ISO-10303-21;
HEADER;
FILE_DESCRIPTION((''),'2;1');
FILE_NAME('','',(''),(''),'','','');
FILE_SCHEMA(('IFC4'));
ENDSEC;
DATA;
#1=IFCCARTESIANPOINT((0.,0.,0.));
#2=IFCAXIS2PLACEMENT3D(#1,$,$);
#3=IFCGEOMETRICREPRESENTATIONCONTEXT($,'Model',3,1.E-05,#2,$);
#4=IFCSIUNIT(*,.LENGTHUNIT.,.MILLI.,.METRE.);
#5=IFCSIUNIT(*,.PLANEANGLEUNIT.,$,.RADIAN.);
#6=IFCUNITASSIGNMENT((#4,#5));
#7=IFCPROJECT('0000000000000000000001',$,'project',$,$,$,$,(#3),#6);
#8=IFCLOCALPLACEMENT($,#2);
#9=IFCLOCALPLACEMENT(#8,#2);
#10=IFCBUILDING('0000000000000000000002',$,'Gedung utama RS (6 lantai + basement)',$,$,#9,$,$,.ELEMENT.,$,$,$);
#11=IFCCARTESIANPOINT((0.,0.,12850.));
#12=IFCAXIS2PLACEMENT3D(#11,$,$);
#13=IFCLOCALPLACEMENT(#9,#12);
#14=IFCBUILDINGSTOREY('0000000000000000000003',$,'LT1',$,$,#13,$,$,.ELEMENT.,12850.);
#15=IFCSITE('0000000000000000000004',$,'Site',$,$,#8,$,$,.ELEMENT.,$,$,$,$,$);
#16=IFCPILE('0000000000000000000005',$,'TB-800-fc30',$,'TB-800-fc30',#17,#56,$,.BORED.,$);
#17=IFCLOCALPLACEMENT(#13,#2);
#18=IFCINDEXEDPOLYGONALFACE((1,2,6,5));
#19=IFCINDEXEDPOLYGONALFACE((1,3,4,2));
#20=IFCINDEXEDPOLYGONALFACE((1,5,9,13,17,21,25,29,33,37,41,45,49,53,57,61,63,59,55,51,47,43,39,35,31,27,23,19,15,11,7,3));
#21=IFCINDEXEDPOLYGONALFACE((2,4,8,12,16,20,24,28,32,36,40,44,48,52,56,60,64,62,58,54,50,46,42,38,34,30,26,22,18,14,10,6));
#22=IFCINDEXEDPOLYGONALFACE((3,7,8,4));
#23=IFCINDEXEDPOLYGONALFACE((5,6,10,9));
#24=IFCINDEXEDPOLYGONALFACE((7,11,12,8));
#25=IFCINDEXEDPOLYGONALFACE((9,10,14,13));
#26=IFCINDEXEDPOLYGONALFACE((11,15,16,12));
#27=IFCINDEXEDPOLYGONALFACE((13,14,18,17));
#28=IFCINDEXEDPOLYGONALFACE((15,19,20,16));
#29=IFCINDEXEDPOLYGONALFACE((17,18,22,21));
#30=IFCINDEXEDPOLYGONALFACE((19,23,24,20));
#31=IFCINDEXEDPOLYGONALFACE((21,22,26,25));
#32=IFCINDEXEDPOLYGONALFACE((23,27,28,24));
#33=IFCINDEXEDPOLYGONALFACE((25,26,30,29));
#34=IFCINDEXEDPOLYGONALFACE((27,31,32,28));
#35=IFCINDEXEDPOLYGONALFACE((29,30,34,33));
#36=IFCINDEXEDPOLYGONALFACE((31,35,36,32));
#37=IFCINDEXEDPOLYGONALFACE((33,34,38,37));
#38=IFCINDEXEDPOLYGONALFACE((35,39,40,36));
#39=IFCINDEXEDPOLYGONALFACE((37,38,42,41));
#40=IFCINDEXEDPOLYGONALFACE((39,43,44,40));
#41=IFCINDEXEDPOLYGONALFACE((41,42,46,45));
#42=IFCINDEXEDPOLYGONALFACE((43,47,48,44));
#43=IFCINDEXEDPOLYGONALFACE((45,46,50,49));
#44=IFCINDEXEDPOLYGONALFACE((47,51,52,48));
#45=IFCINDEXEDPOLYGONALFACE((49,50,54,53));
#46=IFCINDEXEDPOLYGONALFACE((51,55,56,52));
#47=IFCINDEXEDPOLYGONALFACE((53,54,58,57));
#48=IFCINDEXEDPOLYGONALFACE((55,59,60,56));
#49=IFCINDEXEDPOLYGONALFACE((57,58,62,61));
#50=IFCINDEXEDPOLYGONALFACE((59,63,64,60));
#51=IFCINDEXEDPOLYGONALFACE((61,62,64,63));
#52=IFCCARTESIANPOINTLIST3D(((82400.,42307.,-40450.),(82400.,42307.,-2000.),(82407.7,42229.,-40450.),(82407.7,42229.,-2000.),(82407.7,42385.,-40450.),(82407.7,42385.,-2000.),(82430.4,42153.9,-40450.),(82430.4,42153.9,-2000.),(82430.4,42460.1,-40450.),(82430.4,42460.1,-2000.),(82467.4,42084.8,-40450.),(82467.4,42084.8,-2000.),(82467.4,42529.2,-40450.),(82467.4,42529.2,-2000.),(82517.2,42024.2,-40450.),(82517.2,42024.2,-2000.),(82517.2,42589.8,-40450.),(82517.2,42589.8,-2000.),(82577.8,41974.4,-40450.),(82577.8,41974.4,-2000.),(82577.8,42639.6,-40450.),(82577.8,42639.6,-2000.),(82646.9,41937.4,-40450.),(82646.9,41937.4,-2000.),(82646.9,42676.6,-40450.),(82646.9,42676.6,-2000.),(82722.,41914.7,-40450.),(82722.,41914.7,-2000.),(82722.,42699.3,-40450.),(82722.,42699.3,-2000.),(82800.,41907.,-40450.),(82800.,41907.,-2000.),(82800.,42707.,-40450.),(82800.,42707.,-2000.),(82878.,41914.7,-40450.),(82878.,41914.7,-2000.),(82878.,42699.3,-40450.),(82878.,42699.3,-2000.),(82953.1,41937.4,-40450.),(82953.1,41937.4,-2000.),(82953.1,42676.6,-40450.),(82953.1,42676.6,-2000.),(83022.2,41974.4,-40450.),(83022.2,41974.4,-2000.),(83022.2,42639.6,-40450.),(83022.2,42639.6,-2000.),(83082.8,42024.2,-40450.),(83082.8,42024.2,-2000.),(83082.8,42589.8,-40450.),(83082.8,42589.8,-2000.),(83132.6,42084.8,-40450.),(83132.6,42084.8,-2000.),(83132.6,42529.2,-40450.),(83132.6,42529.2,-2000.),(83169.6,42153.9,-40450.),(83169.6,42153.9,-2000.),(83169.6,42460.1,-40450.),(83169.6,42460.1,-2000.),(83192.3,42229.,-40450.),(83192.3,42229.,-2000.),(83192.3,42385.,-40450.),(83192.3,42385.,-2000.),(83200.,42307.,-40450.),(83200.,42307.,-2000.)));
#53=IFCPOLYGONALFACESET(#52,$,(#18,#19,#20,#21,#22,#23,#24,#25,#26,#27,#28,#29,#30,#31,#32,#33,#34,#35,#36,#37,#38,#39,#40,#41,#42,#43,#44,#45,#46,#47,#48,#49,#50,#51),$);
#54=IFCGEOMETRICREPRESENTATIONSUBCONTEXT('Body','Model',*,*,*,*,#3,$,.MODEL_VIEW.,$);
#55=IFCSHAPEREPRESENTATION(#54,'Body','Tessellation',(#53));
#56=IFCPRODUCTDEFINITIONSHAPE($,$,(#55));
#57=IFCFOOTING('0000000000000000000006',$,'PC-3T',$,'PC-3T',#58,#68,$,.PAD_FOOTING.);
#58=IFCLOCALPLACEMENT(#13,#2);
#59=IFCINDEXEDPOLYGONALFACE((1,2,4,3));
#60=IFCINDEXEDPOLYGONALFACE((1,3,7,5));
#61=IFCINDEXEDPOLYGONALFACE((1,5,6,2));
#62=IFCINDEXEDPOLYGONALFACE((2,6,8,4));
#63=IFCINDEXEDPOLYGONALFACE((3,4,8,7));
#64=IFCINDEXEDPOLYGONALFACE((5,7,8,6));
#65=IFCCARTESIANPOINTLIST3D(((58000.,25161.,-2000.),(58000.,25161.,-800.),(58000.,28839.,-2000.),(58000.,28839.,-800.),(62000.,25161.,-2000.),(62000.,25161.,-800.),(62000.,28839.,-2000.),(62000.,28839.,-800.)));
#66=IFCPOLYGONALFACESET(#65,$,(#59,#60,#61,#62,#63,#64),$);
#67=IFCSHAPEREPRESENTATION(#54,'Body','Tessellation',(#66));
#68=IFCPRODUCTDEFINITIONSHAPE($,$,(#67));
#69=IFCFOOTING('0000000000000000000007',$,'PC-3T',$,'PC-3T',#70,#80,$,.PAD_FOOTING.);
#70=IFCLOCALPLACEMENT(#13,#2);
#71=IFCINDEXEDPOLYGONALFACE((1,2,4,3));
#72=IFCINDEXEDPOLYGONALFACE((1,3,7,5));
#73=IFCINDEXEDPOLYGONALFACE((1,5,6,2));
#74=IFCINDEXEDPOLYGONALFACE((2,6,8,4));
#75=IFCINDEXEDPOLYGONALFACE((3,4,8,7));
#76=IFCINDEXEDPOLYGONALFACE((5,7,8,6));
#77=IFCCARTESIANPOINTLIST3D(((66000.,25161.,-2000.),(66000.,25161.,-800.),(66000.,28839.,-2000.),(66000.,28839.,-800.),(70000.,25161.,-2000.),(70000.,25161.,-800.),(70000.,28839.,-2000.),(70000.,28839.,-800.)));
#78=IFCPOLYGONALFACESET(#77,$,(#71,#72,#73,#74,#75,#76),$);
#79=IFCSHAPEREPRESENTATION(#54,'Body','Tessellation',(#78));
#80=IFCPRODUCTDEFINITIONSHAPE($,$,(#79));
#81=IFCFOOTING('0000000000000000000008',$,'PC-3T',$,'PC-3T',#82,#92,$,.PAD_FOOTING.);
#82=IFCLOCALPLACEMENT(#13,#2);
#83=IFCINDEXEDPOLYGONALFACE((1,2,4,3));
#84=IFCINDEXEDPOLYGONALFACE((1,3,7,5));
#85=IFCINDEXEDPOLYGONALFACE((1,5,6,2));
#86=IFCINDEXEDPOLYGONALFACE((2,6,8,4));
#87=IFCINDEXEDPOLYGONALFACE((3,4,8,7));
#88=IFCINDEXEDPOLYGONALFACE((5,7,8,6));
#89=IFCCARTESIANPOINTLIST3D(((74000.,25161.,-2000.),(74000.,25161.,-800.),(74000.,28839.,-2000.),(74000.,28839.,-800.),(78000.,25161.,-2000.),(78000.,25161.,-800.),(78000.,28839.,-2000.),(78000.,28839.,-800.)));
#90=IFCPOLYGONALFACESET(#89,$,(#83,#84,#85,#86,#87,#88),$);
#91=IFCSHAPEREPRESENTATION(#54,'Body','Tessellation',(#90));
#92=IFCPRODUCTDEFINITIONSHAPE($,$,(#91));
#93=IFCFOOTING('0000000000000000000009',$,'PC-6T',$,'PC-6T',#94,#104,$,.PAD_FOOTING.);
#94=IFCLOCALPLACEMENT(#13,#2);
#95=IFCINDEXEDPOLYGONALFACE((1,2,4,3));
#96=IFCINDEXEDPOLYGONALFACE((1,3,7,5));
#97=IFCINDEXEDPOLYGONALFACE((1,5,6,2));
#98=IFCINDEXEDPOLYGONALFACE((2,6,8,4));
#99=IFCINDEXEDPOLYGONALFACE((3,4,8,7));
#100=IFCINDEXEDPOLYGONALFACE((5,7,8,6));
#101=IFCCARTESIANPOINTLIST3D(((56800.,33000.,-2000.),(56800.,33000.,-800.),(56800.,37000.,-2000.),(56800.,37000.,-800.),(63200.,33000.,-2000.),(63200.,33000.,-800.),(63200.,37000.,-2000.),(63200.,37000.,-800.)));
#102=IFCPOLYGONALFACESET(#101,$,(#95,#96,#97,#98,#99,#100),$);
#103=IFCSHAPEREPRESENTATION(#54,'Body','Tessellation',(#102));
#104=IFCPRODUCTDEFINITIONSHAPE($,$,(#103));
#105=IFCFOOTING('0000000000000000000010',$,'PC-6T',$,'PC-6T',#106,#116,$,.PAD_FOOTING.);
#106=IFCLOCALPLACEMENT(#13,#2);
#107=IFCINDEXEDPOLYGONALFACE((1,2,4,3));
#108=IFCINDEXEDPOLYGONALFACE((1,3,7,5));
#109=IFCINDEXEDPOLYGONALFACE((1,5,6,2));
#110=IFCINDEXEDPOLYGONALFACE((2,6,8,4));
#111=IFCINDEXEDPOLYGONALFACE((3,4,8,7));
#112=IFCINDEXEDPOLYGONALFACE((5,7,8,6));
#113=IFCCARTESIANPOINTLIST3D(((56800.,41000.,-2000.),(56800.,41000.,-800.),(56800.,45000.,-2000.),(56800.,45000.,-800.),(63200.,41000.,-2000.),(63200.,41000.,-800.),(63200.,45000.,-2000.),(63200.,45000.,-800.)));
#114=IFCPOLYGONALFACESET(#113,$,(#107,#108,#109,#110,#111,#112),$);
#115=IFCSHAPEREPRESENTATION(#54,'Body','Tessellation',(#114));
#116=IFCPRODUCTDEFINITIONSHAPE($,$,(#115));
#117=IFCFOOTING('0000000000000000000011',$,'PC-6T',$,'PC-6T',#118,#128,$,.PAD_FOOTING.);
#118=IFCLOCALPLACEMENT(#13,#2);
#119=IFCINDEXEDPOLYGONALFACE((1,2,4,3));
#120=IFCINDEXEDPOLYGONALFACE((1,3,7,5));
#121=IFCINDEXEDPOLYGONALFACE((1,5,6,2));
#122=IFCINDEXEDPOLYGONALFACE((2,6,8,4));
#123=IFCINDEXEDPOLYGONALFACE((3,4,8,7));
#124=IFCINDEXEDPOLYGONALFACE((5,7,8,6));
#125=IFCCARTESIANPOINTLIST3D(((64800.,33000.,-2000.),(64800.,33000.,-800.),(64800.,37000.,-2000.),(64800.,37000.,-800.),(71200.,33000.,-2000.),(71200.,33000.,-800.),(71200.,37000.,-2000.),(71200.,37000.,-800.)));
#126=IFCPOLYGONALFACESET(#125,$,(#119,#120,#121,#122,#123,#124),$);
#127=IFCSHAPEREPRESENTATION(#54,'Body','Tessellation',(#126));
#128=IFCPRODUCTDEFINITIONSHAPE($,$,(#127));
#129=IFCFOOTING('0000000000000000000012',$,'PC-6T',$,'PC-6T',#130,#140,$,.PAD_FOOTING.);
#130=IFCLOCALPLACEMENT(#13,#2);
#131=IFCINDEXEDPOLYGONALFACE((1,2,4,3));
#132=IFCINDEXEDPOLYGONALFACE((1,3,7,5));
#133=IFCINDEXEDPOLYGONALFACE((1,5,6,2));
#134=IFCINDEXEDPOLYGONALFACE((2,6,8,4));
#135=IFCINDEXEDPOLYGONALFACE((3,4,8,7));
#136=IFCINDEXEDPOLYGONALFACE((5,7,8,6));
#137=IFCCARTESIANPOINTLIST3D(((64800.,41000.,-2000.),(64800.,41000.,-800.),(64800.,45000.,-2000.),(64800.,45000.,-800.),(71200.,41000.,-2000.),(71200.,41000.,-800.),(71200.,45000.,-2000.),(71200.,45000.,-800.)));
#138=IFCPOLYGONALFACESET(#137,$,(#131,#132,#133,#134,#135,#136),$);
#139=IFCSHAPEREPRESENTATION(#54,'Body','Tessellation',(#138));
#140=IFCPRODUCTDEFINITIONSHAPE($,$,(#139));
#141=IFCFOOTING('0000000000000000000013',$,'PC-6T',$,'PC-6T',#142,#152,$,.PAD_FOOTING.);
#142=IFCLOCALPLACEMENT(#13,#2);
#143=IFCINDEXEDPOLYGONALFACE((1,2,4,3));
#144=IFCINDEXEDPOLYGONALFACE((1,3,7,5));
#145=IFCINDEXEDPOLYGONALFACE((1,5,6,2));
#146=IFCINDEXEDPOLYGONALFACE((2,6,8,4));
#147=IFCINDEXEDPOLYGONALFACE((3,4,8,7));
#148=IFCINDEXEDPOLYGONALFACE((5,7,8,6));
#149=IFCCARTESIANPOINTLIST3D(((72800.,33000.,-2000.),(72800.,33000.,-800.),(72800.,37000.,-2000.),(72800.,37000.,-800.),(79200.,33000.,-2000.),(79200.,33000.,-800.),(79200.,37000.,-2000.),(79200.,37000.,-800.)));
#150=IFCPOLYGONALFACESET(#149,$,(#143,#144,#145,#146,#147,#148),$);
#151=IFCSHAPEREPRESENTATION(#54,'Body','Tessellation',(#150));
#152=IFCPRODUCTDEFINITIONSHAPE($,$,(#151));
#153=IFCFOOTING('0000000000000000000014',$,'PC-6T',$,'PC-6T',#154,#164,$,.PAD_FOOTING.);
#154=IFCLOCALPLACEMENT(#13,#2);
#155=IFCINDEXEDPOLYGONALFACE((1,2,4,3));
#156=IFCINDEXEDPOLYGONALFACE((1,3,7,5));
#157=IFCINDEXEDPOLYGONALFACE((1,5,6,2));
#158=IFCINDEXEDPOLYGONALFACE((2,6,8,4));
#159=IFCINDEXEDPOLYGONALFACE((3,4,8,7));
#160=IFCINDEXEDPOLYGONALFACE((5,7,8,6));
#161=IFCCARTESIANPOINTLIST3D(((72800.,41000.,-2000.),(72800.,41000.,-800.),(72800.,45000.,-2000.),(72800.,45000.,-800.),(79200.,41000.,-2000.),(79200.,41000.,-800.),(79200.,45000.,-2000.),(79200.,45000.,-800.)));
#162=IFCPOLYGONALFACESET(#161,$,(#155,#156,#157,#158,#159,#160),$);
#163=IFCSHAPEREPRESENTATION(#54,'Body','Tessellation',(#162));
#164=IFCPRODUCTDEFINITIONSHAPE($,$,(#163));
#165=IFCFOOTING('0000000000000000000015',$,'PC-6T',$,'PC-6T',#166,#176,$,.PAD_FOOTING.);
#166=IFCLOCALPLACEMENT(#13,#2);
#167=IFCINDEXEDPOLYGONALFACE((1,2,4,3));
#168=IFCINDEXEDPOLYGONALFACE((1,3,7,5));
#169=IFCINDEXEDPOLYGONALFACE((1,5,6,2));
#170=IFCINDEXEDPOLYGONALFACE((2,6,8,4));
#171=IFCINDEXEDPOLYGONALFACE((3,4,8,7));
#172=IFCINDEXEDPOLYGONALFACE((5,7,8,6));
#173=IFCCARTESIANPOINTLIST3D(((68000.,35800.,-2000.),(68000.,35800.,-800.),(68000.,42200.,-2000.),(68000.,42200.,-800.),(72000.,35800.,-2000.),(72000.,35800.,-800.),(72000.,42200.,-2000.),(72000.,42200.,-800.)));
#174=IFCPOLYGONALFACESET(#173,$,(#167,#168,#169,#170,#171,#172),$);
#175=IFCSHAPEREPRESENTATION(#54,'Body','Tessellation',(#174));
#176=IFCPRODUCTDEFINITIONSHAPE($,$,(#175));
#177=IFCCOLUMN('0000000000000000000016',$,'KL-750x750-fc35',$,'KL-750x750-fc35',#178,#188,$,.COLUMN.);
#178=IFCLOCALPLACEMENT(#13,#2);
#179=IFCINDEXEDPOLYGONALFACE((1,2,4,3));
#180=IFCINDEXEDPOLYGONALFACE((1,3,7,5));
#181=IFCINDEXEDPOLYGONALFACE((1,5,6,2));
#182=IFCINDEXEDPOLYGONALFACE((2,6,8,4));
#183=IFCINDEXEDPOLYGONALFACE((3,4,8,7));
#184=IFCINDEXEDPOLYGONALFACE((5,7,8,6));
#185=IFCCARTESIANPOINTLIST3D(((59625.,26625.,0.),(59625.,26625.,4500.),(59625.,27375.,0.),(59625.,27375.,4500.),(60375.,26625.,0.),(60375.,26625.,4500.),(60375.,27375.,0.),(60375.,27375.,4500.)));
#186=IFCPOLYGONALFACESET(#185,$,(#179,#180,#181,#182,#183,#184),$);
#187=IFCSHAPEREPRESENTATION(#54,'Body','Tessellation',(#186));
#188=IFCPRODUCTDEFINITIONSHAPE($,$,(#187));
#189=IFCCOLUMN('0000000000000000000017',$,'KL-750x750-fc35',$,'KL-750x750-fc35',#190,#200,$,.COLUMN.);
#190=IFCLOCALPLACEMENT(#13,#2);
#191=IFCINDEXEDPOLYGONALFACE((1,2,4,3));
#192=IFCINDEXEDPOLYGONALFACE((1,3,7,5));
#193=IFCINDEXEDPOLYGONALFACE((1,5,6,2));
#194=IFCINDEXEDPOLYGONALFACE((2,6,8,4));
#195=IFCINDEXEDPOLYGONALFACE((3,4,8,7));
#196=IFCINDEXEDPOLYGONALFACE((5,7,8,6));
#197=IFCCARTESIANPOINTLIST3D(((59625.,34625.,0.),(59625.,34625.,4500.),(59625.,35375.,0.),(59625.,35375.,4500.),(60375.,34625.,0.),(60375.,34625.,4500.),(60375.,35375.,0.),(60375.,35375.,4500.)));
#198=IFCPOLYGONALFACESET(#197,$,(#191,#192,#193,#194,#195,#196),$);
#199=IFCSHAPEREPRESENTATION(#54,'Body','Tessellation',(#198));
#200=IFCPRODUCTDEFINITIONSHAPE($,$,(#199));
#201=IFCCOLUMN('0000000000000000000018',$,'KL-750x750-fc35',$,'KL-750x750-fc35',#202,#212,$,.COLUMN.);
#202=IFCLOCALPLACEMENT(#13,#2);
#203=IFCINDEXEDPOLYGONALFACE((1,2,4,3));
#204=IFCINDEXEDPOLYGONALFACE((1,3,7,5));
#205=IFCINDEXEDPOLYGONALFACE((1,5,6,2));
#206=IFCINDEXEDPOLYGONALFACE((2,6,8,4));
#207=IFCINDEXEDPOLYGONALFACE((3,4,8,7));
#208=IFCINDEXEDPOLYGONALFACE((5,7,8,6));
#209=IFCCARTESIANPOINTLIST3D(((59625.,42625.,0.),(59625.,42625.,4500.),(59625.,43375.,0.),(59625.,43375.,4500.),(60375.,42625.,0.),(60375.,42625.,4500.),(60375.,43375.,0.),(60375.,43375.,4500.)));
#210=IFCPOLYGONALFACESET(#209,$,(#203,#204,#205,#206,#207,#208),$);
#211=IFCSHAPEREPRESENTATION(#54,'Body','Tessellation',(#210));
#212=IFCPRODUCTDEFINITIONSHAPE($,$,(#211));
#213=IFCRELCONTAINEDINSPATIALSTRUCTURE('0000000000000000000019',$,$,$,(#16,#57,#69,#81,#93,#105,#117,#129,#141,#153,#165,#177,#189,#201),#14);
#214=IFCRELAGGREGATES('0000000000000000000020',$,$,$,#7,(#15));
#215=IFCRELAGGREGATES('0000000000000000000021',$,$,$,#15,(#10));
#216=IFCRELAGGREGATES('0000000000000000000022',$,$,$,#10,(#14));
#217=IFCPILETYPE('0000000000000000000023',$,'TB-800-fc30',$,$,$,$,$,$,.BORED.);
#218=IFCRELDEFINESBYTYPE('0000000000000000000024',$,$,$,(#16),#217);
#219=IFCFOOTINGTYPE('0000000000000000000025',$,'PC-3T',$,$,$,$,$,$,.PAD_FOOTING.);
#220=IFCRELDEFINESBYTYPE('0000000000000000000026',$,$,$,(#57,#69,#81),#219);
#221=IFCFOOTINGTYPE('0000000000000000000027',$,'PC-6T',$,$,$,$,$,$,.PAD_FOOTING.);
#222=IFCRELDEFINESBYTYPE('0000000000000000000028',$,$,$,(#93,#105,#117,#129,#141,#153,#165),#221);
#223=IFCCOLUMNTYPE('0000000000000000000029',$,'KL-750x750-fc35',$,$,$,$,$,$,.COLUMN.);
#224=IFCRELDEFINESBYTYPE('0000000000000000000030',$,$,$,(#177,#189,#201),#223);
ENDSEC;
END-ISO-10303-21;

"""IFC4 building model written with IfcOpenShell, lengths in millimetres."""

from ifc_helpers import new_model, si_unit, frame, origin, origin_2d, place, context, subcontext, project, spatial, rectangle, circle, extrude, material_profile, profile_set, profile_usage, type_object, element, save


model = new_model("IFC4")

# Units and contexts
model_context = context("Model", 3, precision=1e-05, world=origin())
body_context = subcontext(model_context, "Body", "Model", "MODEL_VIEW")
ifc_project = project(units=[si_unit("LENGTHUNIT", "METRE", prefix="MILLI"), si_unit("PLANEANGLEUNIT", "RADIAN")], contexts=[model_context])

# Site, building, storey
site_placement = place(None, origin())
site = spatial("IfcSite", under=ifc_project, at=site_placement, Name="Site", CompositionType="ELEMENT")
building_placement = place(site_placement, origin())
building = spatial("IfcBuilding", under=site, at=building_placement, Name="Gedung utama RS (6 lantai + basement)", CompositionType="ELEMENT")
storey_placement = place(building_placement, frame((0.0, 0.0, 12850.0)))
storey = spatial("IfcBuildingStorey", under=building, at=storey_placement, Name="LT1", CompositionType="ELEMENT", Elevation=12850.0)

# Pile
ifc_material_profile_1 = material_profile(None, circle(Radius=400.0, at=origin_2d()), Name="TB-800-fc30")
ifc_profile_set_1 = profile_set([ifc_material_profile_1], Name="TB-800-fc30")
ifc_profile_usage_1 = profile_usage(ifc_profile_set_1, cardinal=5)
pile_type = type_object("IfcPileType", Name="TB-800-fc30", PredefinedType="BORED", material=ifc_profile_set_1)
for number, where, z_axis, x_axis, name in (
    (1, (82800.0, 42307.0, -40450.0), (0.0, 0.0, 1.0), (1.0, 0.0, 0.0), "TB-800-fc30"),
):
    element("IfcPile", number, at=place(storey_placement, frame(where, z_axis=z_axis, x_axis=x_axis)), inside=storey, type_object=pile_type, material=ifc_profile_usage_1, Name=name, ObjectType="TB-800-fc30", PredefinedType="BORED", context=body_context, shape_type="SweptSolid", body=[
        extrude(circle(Radius=400.0, at=origin_2d()), origin(), (0.0, 0.0, 1.0), 38450.0),
    ])

# Footings
ifc_material_profile_2 = material_profile(None, rectangle(XDim=4000.0, YDim=3678.0, at=origin_2d()), Name="PC-3T")
ifc_profile_set_2 = profile_set([ifc_material_profile_2], Name="PC-3T")
ifc_profile_usage_2 = profile_usage(ifc_profile_set_2, cardinal=5)
footing_type_1 = type_object("IfcFootingType", Name="PC-3T", PredefinedType="PAD_FOOTING", material=ifc_profile_set_2)
for number, where, z_axis, x_axis, name in (
    (2, (60000.0, 27000.0, -2000.0), (0.0, 0.0, 1.0), (1.0, 0.0, 0.0), "PC-3T"),
    (3, (68000.0, 27000.0, -2000.0), (0.0, 0.0, 1.0), (1.0, 0.0, 0.0), "PC-3T"),
    (4, (76000.0, 27000.0, -2000.0), (0.0, 0.0, 1.0), (1.0, 0.0, 0.0), "PC-3T"),
):
    element("IfcFooting", number, at=place(storey_placement, frame(where, z_axis=z_axis, x_axis=x_axis)), inside=storey, type_object=footing_type_1, material=ifc_profile_usage_2, Name=name, ObjectType="PC-3T", PredefinedType="PAD_FOOTING", context=body_context, shape_type="SweptSolid", body=[
        extrude(rectangle(XDim=4000.0, YDim=3678.0, at=origin_2d()), origin(), (0.0, 0.0, 1.0), 1200.0),
    ])
ifc_material_profile_3 = material_profile(None, rectangle(XDim=6400.0, YDim=4000.0, at=origin_2d()), Name="PC-6T")
ifc_profile_set_3 = profile_set([ifc_material_profile_3], Name="PC-6T")
ifc_profile_usage_3 = profile_usage(ifc_profile_set_3, cardinal=5)
footing_type_2 = type_object("IfcFootingType", Name="PC-6T", PredefinedType="PAD_FOOTING", material=ifc_profile_set_3)
for number, where, z_axis, x_axis, name in (
    (5, (60000.0, 35000.0, -2000.0), (0.0, 0.0, 1.0), (1.0, 0.0, 0.0), "PC-6T"),
    (6, (60000.0, 43000.0, -2000.0), (0.0, 0.0, 1.0), (1.0, 0.0, 0.0), "PC-6T"),
    (7, (68000.0, 35000.0, -2000.0), (0.0, 0.0, 1.0), (1.0, 0.0, 0.0), "PC-6T"),
    (8, (68000.0, 43000.0, -2000.0), (0.0, 0.0, 1.0), (1.0, 0.0, 0.0), "PC-6T"),
    (9, (76000.0, 35000.0, -2000.0), (0.0, 0.0, 1.0), (1.0, 0.0, 0.0), "PC-6T"),
    (10, (76000.0, 43000.0, -2000.0), (0.0, 0.0, 1.0), (1.0, 0.0, 0.0), "PC-6T"),
    (11, (70000.0, 39000.0, -2000.0), (0.0, 0.0, 1.0), (0.0, 1.0, 0.0), "PC-6T"),
):
    element("IfcFooting", number, at=place(storey_placement, frame(where, z_axis=z_axis, x_axis=x_axis)), inside=storey, type_object=footing_type_2, material=ifc_profile_usage_3, Name=name, ObjectType="PC-6T", PredefinedType="PAD_FOOTING", context=body_context, shape_type="SweptSolid", body=[
        extrude(rectangle(XDim=6400.0, YDim=4000.0, at=origin_2d()), origin(), (0.0, 0.0, 1.0), 1200.0),
    ])

# Columns
ifc_material_profile_4 = material_profile(None, rectangle(XDim=750.0, YDim=750.0, at=origin_2d()), Name="KL-750x750-fc35")
ifc_profile_set_4 = profile_set([ifc_material_profile_4], Name="KL-750x750-fc35")
ifc_profile_usage_4 = profile_usage(ifc_profile_set_4, cardinal=5)
column_type = type_object("IfcColumnType", Name="KL-750x750-fc35", PredefinedType="COLUMN", material=ifc_profile_set_4)
for number, where, z_axis, x_axis, name in (
    (12, (60000.0, 27000.0, 0.0), (0.0, 0.0, 1.0), (1.0, 0.0, 0.0), "KL-750x750-fc35"),
    (13, (60000.0, 35000.0, 0.0), (0.0, 0.0, 1.0), (1.0, 0.0, 0.0), "KL-750x750-fc35"),
    (14, (60000.0, 43000.0, 0.0), (0.0, 0.0, 1.0), (1.0, 0.0, 0.0), "KL-750x750-fc35"),
):
    element("IfcColumn", number, at=place(storey_placement, frame(where, z_axis=z_axis, x_axis=x_axis)), inside=storey, type_object=column_type, material=ifc_profile_usage_4, Name=name, ObjectType="KL-750x750-fc35", PredefinedType="COLUMN", context=body_context, shape_type="SweptSolid", body=[
        extrude(rectangle(XDim=750.0, YDim=750.0, at=origin_2d()), origin(), (0.0, 0.0, 1.0), 4500.0),
    ])

save(model, "model.ifc")
